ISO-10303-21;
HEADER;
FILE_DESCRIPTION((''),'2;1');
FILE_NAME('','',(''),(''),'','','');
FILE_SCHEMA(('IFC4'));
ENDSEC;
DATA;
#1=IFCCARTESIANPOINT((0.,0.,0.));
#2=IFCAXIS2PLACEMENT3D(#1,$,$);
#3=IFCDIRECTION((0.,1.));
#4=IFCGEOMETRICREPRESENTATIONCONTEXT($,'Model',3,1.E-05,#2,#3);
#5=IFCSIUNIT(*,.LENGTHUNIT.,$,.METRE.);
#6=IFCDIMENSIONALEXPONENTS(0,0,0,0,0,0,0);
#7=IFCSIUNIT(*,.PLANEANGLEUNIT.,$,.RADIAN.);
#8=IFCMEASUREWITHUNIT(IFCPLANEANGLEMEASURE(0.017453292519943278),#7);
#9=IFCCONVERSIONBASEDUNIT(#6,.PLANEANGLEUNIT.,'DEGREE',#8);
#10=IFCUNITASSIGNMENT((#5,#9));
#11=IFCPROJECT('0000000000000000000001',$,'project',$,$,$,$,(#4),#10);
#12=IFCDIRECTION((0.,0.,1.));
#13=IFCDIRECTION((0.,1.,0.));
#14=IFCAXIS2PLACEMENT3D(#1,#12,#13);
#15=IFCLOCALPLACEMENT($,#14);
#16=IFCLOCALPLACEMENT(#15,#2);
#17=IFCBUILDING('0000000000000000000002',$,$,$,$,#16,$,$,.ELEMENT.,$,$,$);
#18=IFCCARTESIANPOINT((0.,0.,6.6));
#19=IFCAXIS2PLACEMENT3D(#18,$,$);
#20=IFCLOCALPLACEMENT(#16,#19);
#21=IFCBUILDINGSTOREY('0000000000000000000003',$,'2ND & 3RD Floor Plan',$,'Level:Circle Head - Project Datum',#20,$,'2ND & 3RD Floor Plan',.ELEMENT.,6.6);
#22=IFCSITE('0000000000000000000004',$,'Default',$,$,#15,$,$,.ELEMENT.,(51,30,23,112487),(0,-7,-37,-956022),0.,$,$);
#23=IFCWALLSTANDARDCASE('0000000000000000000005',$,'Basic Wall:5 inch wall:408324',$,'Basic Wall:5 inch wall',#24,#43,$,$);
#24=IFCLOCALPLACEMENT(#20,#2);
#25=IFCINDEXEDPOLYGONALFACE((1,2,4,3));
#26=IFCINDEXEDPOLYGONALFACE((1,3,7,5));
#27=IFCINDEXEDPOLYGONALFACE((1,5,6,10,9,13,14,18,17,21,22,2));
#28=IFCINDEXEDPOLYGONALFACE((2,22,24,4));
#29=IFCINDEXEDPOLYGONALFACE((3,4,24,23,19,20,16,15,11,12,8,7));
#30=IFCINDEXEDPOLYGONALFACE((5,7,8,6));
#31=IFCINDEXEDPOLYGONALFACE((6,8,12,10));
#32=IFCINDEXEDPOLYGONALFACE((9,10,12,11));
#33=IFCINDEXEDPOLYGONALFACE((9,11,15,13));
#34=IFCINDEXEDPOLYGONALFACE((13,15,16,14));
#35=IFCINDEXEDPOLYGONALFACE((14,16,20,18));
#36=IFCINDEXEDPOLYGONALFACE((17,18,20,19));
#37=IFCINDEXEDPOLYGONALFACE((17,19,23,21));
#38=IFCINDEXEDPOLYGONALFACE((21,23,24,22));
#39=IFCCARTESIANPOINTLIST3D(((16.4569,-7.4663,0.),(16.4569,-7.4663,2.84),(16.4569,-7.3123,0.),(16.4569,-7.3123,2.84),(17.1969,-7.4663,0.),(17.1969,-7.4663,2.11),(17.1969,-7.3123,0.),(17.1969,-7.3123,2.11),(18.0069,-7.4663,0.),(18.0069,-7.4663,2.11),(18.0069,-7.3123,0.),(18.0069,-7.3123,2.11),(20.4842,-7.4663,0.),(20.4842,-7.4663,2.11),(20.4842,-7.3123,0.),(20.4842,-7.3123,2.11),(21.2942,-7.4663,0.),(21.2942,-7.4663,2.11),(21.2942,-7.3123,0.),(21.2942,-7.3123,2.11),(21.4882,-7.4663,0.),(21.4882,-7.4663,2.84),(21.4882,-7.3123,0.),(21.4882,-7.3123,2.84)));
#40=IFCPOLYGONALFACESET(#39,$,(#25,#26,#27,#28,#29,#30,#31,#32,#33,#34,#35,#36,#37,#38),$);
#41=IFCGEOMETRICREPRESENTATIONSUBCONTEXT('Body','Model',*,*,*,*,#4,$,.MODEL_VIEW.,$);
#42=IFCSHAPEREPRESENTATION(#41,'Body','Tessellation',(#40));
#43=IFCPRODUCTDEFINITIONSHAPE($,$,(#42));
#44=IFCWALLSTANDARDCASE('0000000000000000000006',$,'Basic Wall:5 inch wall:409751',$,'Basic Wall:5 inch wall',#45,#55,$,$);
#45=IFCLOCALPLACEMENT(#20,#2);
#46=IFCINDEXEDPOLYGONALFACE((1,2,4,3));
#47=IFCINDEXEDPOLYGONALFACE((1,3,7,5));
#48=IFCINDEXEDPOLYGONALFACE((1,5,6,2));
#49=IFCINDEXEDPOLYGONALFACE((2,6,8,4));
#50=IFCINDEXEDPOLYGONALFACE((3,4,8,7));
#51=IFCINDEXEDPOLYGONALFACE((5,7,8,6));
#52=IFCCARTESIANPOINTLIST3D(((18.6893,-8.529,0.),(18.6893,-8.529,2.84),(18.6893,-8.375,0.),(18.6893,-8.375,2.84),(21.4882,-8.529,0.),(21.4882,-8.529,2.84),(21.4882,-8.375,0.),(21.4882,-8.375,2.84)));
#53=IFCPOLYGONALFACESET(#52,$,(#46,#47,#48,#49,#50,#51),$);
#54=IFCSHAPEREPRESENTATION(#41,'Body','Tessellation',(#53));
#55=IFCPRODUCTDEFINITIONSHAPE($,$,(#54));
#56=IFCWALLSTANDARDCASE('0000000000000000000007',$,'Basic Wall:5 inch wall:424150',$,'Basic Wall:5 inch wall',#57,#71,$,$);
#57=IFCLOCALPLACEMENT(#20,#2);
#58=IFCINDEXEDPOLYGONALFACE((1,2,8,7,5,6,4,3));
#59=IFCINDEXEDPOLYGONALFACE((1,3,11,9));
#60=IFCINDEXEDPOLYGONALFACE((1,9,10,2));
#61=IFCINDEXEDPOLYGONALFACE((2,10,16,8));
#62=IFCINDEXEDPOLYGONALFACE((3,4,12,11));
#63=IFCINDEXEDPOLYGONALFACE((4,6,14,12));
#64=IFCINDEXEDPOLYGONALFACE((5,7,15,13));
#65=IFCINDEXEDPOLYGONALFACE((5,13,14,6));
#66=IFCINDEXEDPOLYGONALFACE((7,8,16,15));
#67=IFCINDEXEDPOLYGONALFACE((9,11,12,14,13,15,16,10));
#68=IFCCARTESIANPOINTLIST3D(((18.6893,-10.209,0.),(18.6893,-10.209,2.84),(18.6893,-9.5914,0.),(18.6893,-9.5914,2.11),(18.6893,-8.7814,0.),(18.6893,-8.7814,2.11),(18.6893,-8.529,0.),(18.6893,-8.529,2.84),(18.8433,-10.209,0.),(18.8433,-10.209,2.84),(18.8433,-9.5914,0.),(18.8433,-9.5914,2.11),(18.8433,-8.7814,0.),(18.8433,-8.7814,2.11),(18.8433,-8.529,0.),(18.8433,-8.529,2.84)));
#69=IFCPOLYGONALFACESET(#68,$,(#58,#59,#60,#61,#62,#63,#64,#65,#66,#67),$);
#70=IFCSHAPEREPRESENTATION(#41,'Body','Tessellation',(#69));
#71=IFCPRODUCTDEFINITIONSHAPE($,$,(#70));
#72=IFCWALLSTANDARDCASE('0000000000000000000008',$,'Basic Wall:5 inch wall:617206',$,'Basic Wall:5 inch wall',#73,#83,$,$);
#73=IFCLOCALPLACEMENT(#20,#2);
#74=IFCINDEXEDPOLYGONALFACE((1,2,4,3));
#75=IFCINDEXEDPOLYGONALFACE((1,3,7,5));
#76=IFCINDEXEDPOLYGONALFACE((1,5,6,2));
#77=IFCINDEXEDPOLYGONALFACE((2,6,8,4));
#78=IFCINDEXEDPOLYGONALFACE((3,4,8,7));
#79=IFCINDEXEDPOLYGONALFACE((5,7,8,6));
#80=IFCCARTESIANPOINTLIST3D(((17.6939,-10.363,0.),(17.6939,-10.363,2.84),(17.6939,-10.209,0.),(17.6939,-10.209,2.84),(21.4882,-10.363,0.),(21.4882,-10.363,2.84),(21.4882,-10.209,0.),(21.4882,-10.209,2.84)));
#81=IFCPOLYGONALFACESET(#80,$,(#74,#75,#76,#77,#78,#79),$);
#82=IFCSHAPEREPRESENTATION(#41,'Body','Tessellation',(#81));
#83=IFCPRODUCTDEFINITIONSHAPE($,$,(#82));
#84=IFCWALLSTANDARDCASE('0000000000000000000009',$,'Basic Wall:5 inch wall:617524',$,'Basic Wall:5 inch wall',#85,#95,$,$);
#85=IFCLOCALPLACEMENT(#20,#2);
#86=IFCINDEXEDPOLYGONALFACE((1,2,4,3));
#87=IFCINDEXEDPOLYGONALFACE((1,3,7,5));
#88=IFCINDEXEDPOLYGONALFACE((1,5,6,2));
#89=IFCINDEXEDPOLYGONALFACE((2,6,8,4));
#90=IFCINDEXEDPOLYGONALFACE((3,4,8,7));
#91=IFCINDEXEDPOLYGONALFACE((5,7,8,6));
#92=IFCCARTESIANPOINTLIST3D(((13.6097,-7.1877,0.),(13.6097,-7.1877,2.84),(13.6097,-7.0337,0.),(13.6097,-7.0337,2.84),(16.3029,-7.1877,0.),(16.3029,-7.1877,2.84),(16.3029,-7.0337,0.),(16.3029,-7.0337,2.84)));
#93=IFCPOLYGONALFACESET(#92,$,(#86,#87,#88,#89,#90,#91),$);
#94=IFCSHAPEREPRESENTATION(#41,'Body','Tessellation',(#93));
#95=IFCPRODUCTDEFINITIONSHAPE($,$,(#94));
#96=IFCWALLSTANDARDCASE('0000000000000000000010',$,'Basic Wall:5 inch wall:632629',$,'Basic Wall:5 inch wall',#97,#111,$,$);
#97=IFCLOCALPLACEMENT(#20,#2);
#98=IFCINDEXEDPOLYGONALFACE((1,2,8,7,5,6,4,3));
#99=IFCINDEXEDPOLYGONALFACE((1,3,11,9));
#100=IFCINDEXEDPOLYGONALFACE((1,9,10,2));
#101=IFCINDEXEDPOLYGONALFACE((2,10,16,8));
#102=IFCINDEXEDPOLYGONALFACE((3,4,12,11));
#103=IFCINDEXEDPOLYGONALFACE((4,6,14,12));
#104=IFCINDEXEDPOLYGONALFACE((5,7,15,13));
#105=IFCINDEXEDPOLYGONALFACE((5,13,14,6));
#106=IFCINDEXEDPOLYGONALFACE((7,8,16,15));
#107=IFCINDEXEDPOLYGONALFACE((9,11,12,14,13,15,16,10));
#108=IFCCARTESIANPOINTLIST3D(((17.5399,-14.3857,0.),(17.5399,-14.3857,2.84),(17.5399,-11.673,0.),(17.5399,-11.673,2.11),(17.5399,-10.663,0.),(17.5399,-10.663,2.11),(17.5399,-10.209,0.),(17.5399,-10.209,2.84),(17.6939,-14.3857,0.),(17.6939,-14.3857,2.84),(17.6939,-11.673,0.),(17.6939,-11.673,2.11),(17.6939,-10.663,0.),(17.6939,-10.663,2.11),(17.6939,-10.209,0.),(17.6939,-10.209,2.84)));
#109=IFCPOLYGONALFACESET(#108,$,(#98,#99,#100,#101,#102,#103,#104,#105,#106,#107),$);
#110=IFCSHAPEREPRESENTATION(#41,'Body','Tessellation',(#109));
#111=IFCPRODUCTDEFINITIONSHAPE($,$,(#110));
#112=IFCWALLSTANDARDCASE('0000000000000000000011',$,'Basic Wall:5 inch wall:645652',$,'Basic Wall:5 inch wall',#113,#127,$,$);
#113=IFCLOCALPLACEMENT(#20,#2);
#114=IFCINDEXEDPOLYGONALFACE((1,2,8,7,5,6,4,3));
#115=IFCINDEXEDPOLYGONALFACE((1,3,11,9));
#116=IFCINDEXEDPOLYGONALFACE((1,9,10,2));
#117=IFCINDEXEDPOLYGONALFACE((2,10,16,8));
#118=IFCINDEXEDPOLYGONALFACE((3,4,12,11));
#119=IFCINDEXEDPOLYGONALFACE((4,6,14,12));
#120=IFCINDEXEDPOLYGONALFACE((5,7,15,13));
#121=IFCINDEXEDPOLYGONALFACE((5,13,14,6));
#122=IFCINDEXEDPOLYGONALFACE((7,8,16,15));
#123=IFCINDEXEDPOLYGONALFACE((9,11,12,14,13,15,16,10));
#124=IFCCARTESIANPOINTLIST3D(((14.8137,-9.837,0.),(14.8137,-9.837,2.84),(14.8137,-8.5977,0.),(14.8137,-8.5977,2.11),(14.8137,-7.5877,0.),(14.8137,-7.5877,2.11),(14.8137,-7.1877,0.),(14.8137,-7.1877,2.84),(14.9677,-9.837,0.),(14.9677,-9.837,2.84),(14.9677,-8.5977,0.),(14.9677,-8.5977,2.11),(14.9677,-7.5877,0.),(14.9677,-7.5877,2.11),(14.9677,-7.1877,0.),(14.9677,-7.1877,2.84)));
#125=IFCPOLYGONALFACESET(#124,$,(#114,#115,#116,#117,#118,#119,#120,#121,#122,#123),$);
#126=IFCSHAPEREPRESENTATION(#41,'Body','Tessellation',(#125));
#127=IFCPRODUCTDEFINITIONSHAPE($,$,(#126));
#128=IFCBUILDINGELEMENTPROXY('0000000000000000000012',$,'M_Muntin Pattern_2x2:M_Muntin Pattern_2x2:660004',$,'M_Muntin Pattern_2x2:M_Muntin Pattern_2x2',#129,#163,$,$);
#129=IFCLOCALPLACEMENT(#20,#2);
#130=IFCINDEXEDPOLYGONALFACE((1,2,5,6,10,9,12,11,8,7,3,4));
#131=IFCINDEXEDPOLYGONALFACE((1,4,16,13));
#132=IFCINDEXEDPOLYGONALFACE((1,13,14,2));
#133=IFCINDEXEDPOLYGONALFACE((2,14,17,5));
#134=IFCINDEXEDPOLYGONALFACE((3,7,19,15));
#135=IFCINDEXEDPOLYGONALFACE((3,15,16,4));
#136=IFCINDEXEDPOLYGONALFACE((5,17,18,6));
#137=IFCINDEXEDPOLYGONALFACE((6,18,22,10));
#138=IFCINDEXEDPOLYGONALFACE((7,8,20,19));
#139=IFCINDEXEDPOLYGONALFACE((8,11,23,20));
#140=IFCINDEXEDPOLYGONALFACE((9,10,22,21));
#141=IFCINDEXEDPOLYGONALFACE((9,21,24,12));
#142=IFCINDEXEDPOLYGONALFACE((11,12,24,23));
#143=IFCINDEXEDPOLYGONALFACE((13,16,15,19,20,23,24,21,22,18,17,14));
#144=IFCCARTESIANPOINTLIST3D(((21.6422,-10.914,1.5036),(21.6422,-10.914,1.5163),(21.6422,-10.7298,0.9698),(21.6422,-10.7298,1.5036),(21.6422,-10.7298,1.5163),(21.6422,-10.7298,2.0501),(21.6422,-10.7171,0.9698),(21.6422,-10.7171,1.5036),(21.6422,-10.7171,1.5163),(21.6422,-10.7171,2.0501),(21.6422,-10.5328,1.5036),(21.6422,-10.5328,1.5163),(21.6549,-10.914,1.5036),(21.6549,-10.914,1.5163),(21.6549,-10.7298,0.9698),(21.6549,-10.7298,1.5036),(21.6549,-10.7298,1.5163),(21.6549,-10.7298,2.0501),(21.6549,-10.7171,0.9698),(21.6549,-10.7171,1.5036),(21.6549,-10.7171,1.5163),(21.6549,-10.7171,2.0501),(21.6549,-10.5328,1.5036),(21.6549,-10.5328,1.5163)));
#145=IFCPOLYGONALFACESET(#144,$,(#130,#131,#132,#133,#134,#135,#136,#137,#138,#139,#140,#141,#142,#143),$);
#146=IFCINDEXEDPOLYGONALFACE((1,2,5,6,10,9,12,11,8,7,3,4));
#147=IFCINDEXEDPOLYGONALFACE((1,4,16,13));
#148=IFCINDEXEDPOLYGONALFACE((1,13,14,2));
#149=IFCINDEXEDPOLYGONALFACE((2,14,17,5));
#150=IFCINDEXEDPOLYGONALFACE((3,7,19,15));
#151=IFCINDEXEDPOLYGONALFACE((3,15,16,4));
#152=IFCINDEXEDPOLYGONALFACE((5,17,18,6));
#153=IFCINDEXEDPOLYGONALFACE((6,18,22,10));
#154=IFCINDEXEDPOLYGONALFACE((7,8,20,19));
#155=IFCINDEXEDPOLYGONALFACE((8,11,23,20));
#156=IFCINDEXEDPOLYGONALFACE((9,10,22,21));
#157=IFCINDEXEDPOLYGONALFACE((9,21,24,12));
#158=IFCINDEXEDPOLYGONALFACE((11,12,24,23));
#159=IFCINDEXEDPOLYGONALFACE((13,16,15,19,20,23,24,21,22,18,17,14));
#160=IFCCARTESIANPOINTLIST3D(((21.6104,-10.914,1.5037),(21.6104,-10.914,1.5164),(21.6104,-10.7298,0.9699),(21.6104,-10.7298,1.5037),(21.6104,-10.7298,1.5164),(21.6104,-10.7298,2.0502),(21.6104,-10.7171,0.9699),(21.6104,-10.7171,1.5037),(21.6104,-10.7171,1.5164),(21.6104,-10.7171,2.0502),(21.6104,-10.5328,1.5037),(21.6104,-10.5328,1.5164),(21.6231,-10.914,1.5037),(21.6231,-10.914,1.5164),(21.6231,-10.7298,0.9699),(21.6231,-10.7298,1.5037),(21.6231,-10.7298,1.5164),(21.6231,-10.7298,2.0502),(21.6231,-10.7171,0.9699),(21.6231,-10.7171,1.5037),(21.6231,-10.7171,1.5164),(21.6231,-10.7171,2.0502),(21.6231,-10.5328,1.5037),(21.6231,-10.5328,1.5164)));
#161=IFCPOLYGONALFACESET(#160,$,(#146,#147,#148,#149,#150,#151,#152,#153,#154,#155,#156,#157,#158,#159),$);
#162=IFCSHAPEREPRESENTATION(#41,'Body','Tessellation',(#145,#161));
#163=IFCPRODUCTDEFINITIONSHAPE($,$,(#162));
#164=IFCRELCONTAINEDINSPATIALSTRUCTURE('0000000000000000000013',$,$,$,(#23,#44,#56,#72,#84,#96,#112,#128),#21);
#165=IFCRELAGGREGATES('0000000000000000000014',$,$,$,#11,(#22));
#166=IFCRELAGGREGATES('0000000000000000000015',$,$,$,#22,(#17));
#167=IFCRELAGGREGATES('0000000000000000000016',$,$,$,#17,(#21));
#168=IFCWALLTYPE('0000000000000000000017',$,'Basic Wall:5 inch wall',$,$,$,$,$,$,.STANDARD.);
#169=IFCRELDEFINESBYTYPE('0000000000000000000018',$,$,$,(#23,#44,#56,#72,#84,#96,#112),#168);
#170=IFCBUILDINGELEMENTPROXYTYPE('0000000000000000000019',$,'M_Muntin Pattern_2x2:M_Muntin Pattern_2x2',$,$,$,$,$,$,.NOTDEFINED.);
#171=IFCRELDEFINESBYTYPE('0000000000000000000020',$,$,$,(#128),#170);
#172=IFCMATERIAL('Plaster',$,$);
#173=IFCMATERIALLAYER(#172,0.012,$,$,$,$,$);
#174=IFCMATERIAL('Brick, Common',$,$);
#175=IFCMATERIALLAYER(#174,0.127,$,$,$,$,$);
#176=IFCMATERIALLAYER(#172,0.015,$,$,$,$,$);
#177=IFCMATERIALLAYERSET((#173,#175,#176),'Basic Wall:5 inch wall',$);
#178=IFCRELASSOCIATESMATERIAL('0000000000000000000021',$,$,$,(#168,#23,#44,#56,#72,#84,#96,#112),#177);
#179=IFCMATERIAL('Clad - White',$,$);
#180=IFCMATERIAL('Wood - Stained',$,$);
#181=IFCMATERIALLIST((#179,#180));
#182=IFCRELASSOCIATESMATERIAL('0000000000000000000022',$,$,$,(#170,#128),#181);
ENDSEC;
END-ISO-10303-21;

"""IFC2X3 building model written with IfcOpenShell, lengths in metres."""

from ifc_helpers import new_model, entity, si_unit, converted_unit, direction, frame, frame_2d, origin, place, context, subcontext, project, spatial, polyline, rectangle, outline, extrude, source, transform, mapped, material, material_list, layer, layer_set, layer_usage, type_object, type_shapes, element, save


model = new_model("IFC2X3")

# Units and contexts
model_context = context("Model", 3, precision=1e-05, world=origin(), true_north=direction((0.0, 1.0)))
body_context = subcontext(model_context, "Body", "Model", "MODEL_VIEW")
ifc_project = project(units=[si_unit("LENGTHUNIT", "METRE"), converted_unit("PLANEANGLEUNIT", "DEGREE", entity("IfcPlaneAngleMeasure", 0.017453292519943278), si_unit("PLANEANGLEUNIT", "RADIAN"), dimensions=[0, 0, 0, 0, 0, 0, 0])], contexts=[model_context])

# Site, building, storey
site_placement = place(None, frame((0.0, 0.0, 0.0), z_axis=(0.0, 0.0, 1.0), x_axis=(0.0, 1.0, 0.0)))
site = spatial("IfcSite", under=ifc_project, at=site_placement, Name="Default", CompositionType="ELEMENT", RefLatitude=(51, 30, 23, 112487), RefLongitude=(0, -7, -37, -956022), RefElevation=0.0)
building_placement = place(site_placement, origin())
building = spatial("IfcBuilding", under=site, at=building_placement, CompositionType="ELEMENT")
storey_placement = place(building_placement, frame((0.0, 0.0, 6.6)))
storey = spatial("IfcBuildingStorey", under=building, at=storey_placement, Name="2ND & 3RD Floor Plan", ObjectType="Level:Circle Head - Project Datum", LongName="2ND & 3RD Floor Plan", CompositionType="ELEMENT", Elevation=6.6)

# Wall, openings
ifc_material_1 = material(Name="Plaster")
ifc_layer_1 = layer(ifc_material_1, 0.012)
ifc_material_2 = material(Name="Brick, Common")
ifc_layer_2 = layer(ifc_material_2, 0.127)
ifc_layer_3 = layer(ifc_material_1, 0.015)
ifc_layer_set = layer_set([ifc_layer_1, ifc_layer_2, ifc_layer_3], Name="Basic Wall:5 inch wall")
ifc_layer_usage_1 = layer_usage(ifc_layer_set, "AXIS2", "NEGATIVE", 0.077)
wall_type = type_object("IfcWallType", Name="Basic Wall:5 inch wall", PredefinedType="STANDARD", material=ifc_layer_set)
wall_1_placement = place(storey_placement, frame((21.4882, -7.3893, 0.0), z_axis=(0.0, 0.0, 1.0), x_axis=(-1.0, 0.0, 0.0)))
wall_1 = element("IfcWallStandardCase", 1, at=wall_1_placement, inside=storey, type_object=wall_type, material=ifc_layer_usage_1, Name="Basic Wall:5 inch wall:408324", ObjectType="Basic Wall:5 inch wall", context=body_context, shape_type="SweptSolid", body=[
    extrude(rectangle(XDim=5.0312, YDim=0.154, at=frame_2d((2.5156, 0.0), x_axis=(-1.0, 0.0))), origin(), (0.0, 0.0, 1.0), 2.84),
])
opening_1_placement = place(wall_1_placement, frame((4.2912, 0.077, 0.0)))
element("IfcOpeningElement", 2, at=opening_1_placement, cuts=wall_1, ObjectType="Opening", context=body_context, shape_type="SweptSolid", body=[
    extrude(rectangle(XDim=2.11, YDim=0.81, at=frame_2d((1.055, 0.405), x_axis=(1.0, 0.0))), frame((0.0, 0.0, 0.0), z_axis=(0.0, -1.0, 0.0), x_axis=(0.0, 0.0, 1.0)), (0.0, 0.0, 1.0), 0.154),
])
opening_2_placement = place(wall_1_placement, frame((1.004, 0.077, 0.0)))
element("IfcOpeningElement", 3, at=opening_2_placement, cuts=wall_1, ObjectType="Opening", context=body_context, shape_type="SweptSolid", body=[
    extrude(rectangle(XDim=2.11, YDim=0.81, at=frame_2d((1.055, 0.405), x_axis=(1.0, 0.0))), frame((0.0, 0.0, 0.0), z_axis=(0.0, -1.0, 0.0), x_axis=(0.0, 0.0, 1.0)), (0.0, 0.0, 1.0), 0.154),
])

# Wall
ifc_layer_usage_2 = layer_usage(ifc_layer_set, "AXIS2", "NEGATIVE", 0.077)
wall_2_placement = place(storey_placement, frame((18.6893, -8.452, 0.0)))
element("IfcWallStandardCase", 4, at=wall_2_placement, inside=storey, type_object=wall_type, material=ifc_layer_usage_2, Name="Basic Wall:5 inch wall:409751", ObjectType="Basic Wall:5 inch wall", context=body_context, shape_type="SweptSolid", body=[
    extrude(rectangle(XDim=2.7989, YDim=0.154, at=frame_2d((1.3994, 0.0), x_axis=(-1.0, 0.0))), origin(), (0.0, 0.0, 1.0), 2.84),
])

# Wall, opening
ifc_layer_usage_3 = layer_usage(ifc_layer_set, "AXIS2", "NEGATIVE", 0.077)
wall_3_placement = place(storey_placement, frame((18.7663, -8.529, 0.0), z_axis=(0.0, 0.0, 1.0), x_axis=(0.0, -1.0, 0.0)))
wall_3 = element("IfcWallStandardCase", 5, at=wall_3_placement, inside=storey, type_object=wall_type, material=ifc_layer_usage_3, Name="Basic Wall:5 inch wall:424150", ObjectType="Basic Wall:5 inch wall", context=body_context, shape_type="SweptSolid", body=[
    extrude(rectangle(XDim=1.68, YDim=0.154, at=frame_2d((0.84, 0.0), x_axis=(-1.0, 0.0))), origin(), (0.0, 0.0, 1.0), 2.84),
])
opening_3_placement = place(wall_3_placement, frame((1.0624, 0.077, 0.0)))
element("IfcOpeningElement", 6, at=opening_3_placement, cuts=wall_3, ObjectType="Opening", context=body_context, shape_type="SweptSolid", body=[
    extrude(rectangle(XDim=2.11, YDim=0.81, at=frame_2d((1.055, 0.405), x_axis=(1.0, 0.0))), frame((0.0, 0.0, 0.0), z_axis=(0.0, -1.0, 0.0), x_axis=(0.0, 0.0, 1.0)), (0.0, 0.0, 1.0), 0.154),
])

# Walls
ifc_layer_usage_4 = layer_usage(ifc_layer_set, "AXIS2", "NEGATIVE", 0.077)
wall_4_placement = place(storey_placement, frame((17.6939, -10.286, 0.0)))
element("IfcWallStandardCase", 7, at=wall_4_placement, inside=storey, type_object=wall_type, material=ifc_layer_usage_4, Name="Basic Wall:5 inch wall:617206", ObjectType="Basic Wall:5 inch wall", context=body_context, shape_type="SweptSolid", body=[
    extrude(rectangle(XDim=3.7942, YDim=0.154, at=frame_2d((1.8971, 0.0), x_axis=(-1.0, 0.0))), origin(), (0.0, 0.0, 1.0), 2.84),
])
ifc_layer_usage_5 = layer_usage(ifc_layer_set, "AXIS2", "NEGATIVE", 0.077)
wall_5_placement = place(storey_placement, frame((16.3029, -7.1107, 0.0), z_axis=(0.0, 0.0, 1.0), x_axis=(-1.0, 0.0, 0.0)))
element("IfcWallStandardCase", 8, at=wall_5_placement, inside=storey, type_object=wall_type, material=ifc_layer_usage_5, Name="Basic Wall:5 inch wall:617524", ObjectType="Basic Wall:5 inch wall", context=body_context, shape_type="SweptSolid", body=[
    extrude(rectangle(XDim=2.6932, YDim=0.154, at=frame_2d((1.3466, 0.0), x_axis=(-1.0, 0.0))), origin(), (0.0, 0.0, 1.0), 2.84),
])

# Walls, openings
ifc_layer_usage_6 = layer_usage(ifc_layer_set, "AXIS2", "NEGATIVE", 0.077)
wall_6_placement = place(storey_placement, frame((17.6169, -10.209, 0.0), z_axis=(0.0, 0.0, 1.0), x_axis=(0.0, -1.0, 0.0)))
wall_6 = element("IfcWallStandardCase", 9, at=wall_6_placement, inside=storey, type_object=wall_type, material=ifc_layer_usage_6, Name="Basic Wall:5 inch wall:632629", ObjectType="Basic Wall:5 inch wall", context=body_context, shape_type="SweptSolid", body=[
    extrude(rectangle(XDim=4.1767, YDim=0.154, at=frame_2d((2.0884, 0.0), x_axis=(1.0, 0.0))), origin(), (0.0, 0.0, 1.0), 2.84),
])
opening_4_placement = place(wall_6_placement, frame((0.454, -0.077, 0.0)))
element("IfcOpeningElement", 10, at=opening_4_placement, cuts=wall_6, ObjectType="Opening", context=body_context, shape_type="SweptSolid", body=[
    extrude(rectangle(XDim=2.11, YDim=1.01, at=frame_2d((1.055, 0.505), x_axis=(1.0, 0.0))), frame((0.0, 0.0, 0.0), z_axis=(0.0, 1.0, 0.0), x_axis=(0.0, 0.0, 1.0)), (0.0, 0.0, 1.0), 0.154),
])
ifc_layer_usage_7 = layer_usage(ifc_layer_set, "AXIS2", "NEGATIVE", 0.077)
wall_7_placement = place(storey_placement, frame((14.8907, -7.1877, 0.0), z_axis=(0.0, 0.0, 1.0), x_axis=(0.0, -1.0, 0.0)))
wall_7 = element("IfcWallStandardCase", 11, at=wall_7_placement, inside=storey, type_object=wall_type, material=ifc_layer_usage_7, Name="Basic Wall:5 inch wall:645652", ObjectType="Basic Wall:5 inch wall", context=body_context, shape_type="SweptSolid", body=[
    extrude(rectangle(XDim=2.6493, YDim=0.154, at=frame_2d((1.3247, 0.0), x_axis=(1.0, 0.0))), origin(), (0.0, 0.0, 1.0), 2.84),
])
opening_5_placement = place(wall_7_placement, frame((0.4, -0.077, 0.0)))
element("IfcOpeningElement", 12, at=opening_5_placement, cuts=wall_7, ObjectType="Opening", context=body_context, shape_type="SweptSolid", body=[
    extrude(rectangle(XDim=2.11, YDim=1.01, at=frame_2d((1.055, 0.505), x_axis=(1.0, 0.0))), frame((0.0, 0.0, 0.0), z_axis=(0.0, 1.0, 0.0), x_axis=(0.0, 0.0, 1.0)), (0.0, 0.0, 1.0), 0.154),
])

# Building element proxy
ifc_material_3 = material(Name="Clad - White")
ifc_material_4 = material(Name="Wood - Stained")
ifc_material_list = material_list([ifc_material_3, ifc_material_4])
building_element_proxy_type_1 = type_object("IfcBuildingElementProxyType", Name="M_Muntin Pattern_2x2:M_Muntin Pattern_2x2", PredefinedType="NOTDEFINED", material=ifc_material_list)
shared_shape_1 = source(origin(), body_context, "Body", "SweptSolid", [
    extrude(outline(polyline([(0.0064, -0.0064), (0.5401, -0.0064), (0.5401, 0.0063), (0.0064, 0.0063), (0.0064, 0.1906), (-0.0063, 0.1906), (-0.0063, 0.0063), (-0.5402, 0.0063), (-0.5402, -0.0064), (-0.0063, -0.0064), (-0.0063, -0.1906), (0.0064, -0.1906), (0.0064, -0.0064)])), frame((0.0, 0.0095, 0.5401), z_axis=(0.0, 1.0, 0.0), x_axis=(0.0, 0.0, 1.0)), (0.0, 0.0, 1.0), 0.0127),
    extrude(outline(polyline([(0.0064, -0.0064), (0.5402, -0.0064), (0.5402, 0.0063), (0.0064, 0.0063), (0.0064, 0.1906), (-0.0063, 0.1906), (-0.0063, 0.0063), (-0.5402, 0.0063), (-0.5402, -0.0064), (-0.0063, -0.0064), (-0.0063, -0.1906), (0.0064, -0.1906), (0.0064, -0.0064)])), frame((0.0, -0.0222, 0.5402), z_axis=(0.0, 1.0, 0.0), x_axis=(0.0, 0.0, 1.0)), (0.0, 0.0, 1.0), 0.0127),
])
type_shapes(building_element_proxy_type_1, [shared_shape_1])
for number, where, z_axis, x_axis, name in (
    (13, (21.6326, -10.7234, 0.9699), (0.0, 0.0, 1.0), (0.0, -1.0, 0.0), "M_Muntin Pattern_2x2:M_Muntin Pattern_2x2:660004"),
):
    element("IfcBuildingElementProxy", number, at=place(storey_placement, frame(where, z_axis=z_axis, x_axis=x_axis)), inside=storey, type_object=building_element_proxy_type_1, material=ifc_material_list, Name=name, ObjectType="M_Muntin Pattern_2x2:M_Muntin Pattern_2x2", context=body_context, shape_type="MappedRepresentation", body=[
        mapped(shared_shape_1, transform((0.0, 0.0, 0.0), scale=1.0)),
    ])

save(model, "model.ifc")
